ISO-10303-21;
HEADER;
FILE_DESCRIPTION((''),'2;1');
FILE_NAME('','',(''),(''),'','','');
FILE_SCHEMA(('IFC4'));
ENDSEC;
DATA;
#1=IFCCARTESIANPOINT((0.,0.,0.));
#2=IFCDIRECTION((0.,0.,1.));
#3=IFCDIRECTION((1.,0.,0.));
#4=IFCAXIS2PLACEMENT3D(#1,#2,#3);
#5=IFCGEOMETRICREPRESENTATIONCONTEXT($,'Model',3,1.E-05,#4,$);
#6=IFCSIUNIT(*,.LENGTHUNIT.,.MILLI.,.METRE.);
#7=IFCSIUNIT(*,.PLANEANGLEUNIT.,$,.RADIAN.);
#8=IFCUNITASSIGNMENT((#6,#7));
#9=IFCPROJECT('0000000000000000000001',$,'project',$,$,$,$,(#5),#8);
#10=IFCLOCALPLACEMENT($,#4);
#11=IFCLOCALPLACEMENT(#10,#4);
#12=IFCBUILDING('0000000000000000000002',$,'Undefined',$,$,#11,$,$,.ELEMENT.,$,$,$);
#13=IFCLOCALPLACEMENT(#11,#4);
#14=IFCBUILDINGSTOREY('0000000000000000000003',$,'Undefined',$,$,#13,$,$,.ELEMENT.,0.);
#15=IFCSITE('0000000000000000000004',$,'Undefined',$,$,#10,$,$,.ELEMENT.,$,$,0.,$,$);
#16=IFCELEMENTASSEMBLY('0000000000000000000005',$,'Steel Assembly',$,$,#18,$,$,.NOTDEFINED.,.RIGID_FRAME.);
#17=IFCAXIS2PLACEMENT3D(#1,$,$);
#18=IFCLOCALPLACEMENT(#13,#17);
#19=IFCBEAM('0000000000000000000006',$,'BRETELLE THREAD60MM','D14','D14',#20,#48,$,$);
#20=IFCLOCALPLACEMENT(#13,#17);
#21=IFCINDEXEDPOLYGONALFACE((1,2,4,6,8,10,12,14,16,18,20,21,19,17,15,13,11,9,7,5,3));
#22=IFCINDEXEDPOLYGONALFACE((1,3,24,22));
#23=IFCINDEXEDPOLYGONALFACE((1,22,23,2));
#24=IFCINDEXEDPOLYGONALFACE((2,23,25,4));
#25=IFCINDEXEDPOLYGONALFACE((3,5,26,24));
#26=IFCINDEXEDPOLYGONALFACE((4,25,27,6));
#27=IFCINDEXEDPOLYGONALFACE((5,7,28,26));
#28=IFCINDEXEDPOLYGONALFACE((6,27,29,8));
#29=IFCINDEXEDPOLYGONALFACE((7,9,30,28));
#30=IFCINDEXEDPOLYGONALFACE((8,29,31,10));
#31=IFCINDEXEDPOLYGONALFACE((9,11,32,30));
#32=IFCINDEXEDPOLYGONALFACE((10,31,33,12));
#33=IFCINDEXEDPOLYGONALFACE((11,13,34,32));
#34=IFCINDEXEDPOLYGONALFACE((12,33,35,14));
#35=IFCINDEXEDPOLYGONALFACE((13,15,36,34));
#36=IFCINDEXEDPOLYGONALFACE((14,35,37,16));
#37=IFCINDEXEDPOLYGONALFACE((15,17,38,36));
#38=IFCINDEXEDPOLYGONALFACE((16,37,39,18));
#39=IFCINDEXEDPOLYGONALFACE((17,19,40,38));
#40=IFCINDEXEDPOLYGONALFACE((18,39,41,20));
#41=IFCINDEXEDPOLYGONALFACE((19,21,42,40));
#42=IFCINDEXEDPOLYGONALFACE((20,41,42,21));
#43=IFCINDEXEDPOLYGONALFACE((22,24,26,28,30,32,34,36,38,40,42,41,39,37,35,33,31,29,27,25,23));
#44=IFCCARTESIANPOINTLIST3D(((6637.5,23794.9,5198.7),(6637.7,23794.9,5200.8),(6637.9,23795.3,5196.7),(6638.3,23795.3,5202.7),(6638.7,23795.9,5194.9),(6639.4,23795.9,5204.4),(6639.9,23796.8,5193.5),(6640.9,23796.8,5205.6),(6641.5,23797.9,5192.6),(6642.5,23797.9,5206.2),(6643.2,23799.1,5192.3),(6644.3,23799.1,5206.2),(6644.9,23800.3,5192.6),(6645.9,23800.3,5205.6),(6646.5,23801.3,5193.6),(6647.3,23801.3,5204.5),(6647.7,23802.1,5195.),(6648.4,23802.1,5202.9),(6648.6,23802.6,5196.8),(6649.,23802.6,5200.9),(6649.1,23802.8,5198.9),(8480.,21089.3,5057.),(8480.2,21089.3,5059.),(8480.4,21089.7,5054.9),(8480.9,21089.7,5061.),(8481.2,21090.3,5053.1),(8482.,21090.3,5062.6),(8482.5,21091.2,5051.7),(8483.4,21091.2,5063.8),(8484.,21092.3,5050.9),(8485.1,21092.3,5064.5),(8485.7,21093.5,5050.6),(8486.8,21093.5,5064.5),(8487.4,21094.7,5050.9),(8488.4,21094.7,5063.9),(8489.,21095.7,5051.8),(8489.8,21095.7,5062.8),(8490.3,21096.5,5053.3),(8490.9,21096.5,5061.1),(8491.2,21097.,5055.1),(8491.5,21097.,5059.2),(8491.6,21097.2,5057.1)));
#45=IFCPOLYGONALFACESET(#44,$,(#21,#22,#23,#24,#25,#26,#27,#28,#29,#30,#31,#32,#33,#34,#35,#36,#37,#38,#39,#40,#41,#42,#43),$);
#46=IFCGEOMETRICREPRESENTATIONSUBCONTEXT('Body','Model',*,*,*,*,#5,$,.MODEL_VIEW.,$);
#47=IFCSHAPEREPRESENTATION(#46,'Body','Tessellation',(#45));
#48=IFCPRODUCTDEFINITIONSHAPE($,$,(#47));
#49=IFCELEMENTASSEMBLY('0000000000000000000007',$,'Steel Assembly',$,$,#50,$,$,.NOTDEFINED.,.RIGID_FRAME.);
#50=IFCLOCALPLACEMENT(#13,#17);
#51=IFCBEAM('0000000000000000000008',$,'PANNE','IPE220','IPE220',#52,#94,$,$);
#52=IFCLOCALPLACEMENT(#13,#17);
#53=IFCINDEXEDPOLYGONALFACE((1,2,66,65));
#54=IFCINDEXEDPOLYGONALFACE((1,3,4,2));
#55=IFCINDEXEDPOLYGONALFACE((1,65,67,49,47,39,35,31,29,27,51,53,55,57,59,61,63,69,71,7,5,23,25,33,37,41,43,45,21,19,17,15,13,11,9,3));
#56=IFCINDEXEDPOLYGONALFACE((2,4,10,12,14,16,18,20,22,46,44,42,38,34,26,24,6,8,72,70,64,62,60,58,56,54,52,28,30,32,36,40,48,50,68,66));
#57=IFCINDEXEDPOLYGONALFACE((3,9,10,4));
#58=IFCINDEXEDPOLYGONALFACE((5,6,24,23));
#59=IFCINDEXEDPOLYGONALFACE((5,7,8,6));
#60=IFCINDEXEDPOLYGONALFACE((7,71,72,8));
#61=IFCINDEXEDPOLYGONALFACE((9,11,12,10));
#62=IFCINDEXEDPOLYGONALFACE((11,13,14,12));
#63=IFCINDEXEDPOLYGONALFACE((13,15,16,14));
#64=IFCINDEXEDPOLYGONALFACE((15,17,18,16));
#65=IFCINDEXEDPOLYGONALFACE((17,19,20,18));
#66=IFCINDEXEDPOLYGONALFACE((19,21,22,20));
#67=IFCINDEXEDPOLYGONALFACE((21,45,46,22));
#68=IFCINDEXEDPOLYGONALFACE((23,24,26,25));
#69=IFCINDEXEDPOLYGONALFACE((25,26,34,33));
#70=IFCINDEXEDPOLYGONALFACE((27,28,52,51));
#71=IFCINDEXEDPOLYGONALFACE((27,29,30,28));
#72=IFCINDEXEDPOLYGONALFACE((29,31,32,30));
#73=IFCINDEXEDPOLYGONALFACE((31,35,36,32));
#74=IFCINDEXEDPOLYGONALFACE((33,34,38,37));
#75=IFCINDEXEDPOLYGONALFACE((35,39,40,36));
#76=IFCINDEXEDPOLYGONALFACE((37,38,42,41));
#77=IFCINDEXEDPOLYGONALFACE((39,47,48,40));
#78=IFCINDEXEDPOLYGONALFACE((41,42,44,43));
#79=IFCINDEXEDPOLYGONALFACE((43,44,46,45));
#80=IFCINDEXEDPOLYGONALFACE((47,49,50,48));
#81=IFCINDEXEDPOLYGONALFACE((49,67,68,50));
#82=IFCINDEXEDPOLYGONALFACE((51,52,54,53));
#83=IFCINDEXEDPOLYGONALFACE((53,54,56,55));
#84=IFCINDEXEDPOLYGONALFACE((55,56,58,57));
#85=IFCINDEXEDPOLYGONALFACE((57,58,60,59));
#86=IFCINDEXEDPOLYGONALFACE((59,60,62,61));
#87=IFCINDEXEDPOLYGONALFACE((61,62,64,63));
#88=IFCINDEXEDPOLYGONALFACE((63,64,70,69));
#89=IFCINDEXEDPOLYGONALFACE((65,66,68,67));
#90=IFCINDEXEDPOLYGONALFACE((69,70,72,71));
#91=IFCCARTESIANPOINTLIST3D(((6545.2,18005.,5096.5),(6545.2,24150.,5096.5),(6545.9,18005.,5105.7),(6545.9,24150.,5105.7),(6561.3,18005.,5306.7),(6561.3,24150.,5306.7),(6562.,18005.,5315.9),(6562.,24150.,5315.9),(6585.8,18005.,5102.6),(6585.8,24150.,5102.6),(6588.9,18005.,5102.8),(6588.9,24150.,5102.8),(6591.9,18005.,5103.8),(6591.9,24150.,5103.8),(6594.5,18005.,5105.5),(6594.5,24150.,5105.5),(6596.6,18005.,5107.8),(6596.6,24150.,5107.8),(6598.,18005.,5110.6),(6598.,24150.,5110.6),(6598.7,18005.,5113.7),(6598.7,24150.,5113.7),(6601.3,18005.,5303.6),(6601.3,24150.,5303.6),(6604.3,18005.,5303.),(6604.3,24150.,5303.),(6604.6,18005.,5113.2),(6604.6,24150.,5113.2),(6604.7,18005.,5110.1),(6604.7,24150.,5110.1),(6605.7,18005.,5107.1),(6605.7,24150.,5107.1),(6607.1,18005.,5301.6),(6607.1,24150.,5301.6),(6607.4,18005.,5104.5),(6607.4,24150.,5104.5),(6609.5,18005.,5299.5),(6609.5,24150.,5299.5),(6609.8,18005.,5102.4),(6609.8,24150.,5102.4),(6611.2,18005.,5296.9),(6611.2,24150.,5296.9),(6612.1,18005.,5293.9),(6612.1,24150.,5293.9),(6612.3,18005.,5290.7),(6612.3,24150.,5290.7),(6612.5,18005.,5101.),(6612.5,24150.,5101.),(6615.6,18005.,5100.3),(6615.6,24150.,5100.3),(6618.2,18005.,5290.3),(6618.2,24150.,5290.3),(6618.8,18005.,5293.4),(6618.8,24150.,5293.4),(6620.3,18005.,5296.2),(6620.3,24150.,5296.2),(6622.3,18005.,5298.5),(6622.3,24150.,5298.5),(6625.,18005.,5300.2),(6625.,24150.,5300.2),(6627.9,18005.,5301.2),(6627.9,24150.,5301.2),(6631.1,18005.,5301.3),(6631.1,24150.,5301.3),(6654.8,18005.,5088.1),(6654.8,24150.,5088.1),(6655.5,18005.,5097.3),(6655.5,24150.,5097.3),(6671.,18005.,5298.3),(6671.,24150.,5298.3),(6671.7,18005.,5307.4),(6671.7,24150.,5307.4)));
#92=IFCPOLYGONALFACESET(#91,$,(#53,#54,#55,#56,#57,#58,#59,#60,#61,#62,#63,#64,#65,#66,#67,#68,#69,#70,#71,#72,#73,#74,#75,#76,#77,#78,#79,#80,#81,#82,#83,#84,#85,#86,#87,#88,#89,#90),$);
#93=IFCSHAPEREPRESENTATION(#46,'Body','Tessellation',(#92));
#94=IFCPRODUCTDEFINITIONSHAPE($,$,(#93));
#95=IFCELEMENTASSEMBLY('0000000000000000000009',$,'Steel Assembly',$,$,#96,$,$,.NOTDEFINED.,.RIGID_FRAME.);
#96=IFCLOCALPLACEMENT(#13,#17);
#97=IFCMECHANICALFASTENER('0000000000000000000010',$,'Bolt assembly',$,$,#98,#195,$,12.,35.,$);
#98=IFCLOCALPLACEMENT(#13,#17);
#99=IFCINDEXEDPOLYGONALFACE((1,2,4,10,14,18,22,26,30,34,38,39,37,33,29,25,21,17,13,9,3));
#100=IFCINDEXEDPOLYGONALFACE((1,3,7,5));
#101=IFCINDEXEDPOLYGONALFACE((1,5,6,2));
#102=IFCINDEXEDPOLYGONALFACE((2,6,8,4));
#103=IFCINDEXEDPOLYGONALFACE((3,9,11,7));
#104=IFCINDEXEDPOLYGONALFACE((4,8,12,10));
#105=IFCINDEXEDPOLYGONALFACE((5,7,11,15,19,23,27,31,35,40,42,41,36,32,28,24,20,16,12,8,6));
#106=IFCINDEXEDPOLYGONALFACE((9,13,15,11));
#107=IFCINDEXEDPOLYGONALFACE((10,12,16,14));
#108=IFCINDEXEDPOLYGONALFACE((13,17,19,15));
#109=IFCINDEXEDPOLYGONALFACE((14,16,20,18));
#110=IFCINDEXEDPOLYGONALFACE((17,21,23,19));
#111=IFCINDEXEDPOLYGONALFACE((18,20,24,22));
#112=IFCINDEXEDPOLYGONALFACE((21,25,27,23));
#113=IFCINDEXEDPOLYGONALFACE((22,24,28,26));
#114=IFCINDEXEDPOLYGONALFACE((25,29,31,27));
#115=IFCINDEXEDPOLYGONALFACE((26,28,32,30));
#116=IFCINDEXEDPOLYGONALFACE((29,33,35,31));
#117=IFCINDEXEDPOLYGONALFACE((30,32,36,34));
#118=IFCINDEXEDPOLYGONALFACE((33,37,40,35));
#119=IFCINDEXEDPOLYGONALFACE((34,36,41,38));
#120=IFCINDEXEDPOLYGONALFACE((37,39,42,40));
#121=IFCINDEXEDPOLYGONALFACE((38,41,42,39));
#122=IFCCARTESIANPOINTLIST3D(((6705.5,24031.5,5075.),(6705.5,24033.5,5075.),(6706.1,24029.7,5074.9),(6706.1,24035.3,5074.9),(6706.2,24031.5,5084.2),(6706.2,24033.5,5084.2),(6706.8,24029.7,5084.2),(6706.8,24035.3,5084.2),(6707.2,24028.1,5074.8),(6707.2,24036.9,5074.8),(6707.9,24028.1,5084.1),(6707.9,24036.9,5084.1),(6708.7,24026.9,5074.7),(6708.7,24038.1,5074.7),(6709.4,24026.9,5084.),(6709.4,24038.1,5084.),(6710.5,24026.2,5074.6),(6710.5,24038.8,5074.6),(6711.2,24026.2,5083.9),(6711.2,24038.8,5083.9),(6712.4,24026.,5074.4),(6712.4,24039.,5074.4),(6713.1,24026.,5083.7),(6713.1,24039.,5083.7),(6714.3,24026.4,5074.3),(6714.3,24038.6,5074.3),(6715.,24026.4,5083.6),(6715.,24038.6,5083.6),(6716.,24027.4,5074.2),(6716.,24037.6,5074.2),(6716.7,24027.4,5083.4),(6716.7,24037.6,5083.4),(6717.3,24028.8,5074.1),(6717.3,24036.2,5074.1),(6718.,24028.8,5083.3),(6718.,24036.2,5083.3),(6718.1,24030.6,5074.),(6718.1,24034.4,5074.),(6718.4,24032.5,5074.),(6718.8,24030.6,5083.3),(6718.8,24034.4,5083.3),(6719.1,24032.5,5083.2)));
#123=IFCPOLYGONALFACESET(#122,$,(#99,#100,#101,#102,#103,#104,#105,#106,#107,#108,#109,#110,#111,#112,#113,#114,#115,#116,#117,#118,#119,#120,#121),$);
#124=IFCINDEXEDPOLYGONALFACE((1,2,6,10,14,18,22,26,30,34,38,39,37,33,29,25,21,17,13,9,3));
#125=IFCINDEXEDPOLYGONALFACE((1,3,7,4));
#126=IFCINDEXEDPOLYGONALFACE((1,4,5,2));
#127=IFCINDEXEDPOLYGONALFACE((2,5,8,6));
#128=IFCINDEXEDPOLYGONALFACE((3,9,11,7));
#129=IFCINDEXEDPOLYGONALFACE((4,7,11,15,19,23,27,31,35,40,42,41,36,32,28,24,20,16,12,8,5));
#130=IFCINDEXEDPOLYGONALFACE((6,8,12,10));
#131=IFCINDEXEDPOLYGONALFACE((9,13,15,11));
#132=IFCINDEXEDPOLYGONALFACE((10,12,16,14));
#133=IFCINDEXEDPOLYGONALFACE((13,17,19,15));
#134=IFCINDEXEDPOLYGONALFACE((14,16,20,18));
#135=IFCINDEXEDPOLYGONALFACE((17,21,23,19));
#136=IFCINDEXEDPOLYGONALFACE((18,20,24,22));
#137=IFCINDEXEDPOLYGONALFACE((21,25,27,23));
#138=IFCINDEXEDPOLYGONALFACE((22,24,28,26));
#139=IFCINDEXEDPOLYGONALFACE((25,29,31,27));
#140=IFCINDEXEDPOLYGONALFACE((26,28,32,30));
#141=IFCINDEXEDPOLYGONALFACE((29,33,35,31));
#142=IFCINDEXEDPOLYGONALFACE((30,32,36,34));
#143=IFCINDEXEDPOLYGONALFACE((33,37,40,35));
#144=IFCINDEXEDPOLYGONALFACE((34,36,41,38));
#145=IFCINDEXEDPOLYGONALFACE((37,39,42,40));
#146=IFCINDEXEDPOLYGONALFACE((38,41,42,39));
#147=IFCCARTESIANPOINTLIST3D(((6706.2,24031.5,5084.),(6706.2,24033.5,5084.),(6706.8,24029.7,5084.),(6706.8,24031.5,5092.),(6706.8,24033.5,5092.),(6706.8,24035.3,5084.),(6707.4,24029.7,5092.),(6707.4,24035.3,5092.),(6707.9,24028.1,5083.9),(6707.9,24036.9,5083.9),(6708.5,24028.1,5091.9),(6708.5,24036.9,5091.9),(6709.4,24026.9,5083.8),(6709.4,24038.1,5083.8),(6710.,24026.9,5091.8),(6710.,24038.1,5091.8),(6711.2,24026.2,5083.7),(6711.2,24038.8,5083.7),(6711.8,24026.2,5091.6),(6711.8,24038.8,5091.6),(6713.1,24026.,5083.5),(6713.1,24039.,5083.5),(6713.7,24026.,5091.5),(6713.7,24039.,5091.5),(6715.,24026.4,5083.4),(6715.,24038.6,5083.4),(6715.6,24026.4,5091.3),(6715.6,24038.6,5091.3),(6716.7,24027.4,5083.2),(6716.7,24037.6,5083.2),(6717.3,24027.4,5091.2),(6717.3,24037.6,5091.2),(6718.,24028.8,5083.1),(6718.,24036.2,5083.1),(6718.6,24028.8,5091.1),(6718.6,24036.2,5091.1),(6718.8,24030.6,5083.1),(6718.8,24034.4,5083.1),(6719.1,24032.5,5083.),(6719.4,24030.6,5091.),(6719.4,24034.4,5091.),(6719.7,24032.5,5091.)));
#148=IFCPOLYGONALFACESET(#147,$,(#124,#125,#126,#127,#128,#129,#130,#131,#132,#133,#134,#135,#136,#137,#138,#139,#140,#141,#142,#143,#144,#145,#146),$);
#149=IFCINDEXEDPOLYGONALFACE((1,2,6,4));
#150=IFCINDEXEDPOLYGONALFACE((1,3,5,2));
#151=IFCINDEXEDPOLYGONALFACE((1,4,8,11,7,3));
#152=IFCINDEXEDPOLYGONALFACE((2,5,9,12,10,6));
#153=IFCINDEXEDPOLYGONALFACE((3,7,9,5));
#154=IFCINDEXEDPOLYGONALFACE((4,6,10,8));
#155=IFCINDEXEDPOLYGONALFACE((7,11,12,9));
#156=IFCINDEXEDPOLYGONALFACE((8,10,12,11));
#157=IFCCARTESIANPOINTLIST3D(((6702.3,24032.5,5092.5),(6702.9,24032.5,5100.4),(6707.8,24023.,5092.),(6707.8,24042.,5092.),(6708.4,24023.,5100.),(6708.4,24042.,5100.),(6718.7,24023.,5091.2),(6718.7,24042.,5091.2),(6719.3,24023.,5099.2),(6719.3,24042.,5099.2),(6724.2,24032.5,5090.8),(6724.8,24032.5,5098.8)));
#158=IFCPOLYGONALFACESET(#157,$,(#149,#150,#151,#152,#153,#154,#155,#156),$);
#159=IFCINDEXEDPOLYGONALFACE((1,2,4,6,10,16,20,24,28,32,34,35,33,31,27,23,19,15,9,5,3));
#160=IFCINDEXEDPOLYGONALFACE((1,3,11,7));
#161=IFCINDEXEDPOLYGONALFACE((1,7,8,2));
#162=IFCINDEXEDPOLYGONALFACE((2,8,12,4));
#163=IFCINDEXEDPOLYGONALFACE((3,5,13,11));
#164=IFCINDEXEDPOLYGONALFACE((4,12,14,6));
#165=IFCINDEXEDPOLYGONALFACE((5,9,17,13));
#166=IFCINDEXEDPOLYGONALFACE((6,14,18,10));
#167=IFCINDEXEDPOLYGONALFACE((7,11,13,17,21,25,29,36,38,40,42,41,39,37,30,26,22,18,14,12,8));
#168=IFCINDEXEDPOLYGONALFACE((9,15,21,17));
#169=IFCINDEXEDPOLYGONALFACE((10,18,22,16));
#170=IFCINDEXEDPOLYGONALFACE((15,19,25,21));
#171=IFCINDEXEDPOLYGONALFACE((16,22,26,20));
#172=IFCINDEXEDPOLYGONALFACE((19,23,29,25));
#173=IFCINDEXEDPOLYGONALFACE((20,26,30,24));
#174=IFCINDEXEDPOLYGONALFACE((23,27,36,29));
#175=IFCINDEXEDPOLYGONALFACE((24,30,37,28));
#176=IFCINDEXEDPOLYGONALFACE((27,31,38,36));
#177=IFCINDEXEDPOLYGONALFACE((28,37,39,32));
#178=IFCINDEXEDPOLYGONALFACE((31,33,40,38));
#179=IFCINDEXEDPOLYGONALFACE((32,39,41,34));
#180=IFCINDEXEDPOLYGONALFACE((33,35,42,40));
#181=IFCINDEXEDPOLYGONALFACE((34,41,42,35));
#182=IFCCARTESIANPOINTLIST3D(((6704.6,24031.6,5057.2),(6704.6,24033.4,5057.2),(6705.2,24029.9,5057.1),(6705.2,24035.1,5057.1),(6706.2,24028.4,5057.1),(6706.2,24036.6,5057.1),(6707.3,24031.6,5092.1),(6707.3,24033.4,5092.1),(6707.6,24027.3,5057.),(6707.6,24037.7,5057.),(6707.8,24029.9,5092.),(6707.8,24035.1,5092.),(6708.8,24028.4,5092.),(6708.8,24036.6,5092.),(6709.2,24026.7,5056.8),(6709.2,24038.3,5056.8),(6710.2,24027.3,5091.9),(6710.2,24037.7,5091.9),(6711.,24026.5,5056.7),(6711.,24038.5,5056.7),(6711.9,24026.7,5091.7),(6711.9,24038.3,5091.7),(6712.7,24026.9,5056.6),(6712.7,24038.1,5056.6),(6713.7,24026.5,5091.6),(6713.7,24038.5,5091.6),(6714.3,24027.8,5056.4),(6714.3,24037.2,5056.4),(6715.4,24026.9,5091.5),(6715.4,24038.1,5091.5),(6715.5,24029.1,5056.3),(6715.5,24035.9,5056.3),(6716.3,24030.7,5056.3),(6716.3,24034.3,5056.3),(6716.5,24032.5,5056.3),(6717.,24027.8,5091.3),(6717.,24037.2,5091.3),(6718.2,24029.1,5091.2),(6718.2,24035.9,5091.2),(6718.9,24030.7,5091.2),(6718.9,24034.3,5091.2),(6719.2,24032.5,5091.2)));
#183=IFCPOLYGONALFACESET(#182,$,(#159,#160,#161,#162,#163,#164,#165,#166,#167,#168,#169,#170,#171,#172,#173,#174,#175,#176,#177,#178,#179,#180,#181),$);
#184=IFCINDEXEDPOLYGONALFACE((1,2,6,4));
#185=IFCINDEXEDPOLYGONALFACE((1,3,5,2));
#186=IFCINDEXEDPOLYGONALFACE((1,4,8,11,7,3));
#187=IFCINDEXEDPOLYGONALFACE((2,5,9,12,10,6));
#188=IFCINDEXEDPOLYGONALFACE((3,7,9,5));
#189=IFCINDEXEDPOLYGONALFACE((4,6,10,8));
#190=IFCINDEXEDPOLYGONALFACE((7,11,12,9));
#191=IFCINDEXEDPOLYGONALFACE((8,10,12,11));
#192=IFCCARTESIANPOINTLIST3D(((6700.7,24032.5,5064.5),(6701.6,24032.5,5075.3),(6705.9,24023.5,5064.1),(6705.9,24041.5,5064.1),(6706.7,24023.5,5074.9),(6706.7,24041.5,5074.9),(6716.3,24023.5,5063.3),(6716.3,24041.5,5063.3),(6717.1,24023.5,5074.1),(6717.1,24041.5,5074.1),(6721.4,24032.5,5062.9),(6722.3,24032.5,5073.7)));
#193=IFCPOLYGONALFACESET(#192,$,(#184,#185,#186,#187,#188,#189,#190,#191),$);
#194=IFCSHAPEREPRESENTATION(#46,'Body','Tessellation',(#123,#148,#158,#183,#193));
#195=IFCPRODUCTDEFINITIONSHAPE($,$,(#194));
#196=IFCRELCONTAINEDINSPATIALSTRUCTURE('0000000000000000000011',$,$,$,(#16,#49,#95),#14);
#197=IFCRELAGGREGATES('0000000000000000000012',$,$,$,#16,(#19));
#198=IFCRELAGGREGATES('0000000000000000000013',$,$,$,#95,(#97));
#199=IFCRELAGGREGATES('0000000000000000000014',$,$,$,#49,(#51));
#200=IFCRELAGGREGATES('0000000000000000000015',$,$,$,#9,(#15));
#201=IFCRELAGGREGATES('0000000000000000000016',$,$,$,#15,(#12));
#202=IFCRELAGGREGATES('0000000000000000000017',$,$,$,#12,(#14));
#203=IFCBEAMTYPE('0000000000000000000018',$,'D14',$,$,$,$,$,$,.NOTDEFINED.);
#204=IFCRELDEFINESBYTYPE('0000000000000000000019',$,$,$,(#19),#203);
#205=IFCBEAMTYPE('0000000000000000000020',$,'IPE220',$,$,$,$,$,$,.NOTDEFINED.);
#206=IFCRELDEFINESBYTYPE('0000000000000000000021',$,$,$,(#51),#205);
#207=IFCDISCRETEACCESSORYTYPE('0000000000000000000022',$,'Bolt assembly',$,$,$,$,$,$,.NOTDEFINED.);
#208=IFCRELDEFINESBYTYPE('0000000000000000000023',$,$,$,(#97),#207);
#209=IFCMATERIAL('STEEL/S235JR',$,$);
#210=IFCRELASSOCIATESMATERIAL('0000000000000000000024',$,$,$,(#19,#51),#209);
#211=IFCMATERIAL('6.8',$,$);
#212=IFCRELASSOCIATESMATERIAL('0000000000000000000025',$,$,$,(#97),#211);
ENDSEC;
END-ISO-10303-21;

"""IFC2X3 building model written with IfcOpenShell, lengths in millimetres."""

from ifc_helpers import new_model, si_unit, frame, origin_with_axes, origin_2d_with_axis, place, context, subcontext, project, spatial, polyline, circle, i_section, outline, extrude, clip, halfspace, source, transform, mapped, material, type_object, element, aggregate, save


model = new_model("IFC2X3")

# Units and contexts
model_context = context("Model", 3, precision=1e-05, world=origin_with_axes())
body_context = subcontext(model_context, "Body", "Model", "MODEL_VIEW")
ifc_project = project(units=[si_unit("LENGTHUNIT", "METRE", prefix="MILLI"), si_unit("PLANEANGLEUNIT", "RADIAN")], contexts=[model_context])

# Site, building, storey
site_placement = place(None, origin_with_axes())
site = spatial("IfcSite", under=ifc_project, at=site_placement, Name="Undefined", CompositionType="ELEMENT", RefElevation=0.0)
building_placement = place(site_placement, origin_with_axes())
building = spatial("IfcBuilding", under=site, at=building_placement, Name="Undefined", CompositionType="ELEMENT")
storey_placement = place(building_placement, origin_with_axes())
storey = spatial("IfcBuildingStorey", under=building, at=storey_placement, Name="Undefined", CompositionType="ELEMENT", Elevation=0.0)

# Element assemblies, beams
assembly_1_placement = place(storey_placement, origin_with_axes())
assembly_1 = element("IfcElementAssembly", 1, at=assembly_1_placement, inside=storey, Name="Steel Assembly", AssemblyPlace="NOTDEFINED", PredefinedType="RIGID_FRAME")
ifc_material_1 = material(Name="STEEL/S235JR")
beam_type_1 = type_object("IfcBeamType", Name="D14", PredefinedType="NOTDEFINED")
beam_1_placement = place(assembly_1_placement, frame((6643.3, 23798.8, 5199.3), z_axis=(-0.076696, 0.0, -0.997054), x_axis=(0.56235, -0.825767, -0.043258)))
beam_1 = element("IfcBeam", 2, at=beam_1_placement, type_object=beam_type_1, material=ifc_material_1, Name="BRETELLE THREAD60MM", Description="D14", ObjectType="D14", context=body_context, shape_type="SweptSolid", body=[
    extrude(circle(Radius=7.0, at=origin_2d_with_axis()), frame((3276.5, 0.0, 0.0), z_axis=(-1.0, 0.0, 0.0), x_axis=(0.0, -1.0, 0.0)), (0.0, 0.0, 1.0), 3276.5),
])
aggregate(assembly_1, [beam_1])
assembly_2_placement = place(storey_placement, origin_with_axes())
assembly_2 = element("IfcElementAssembly", 3, at=assembly_2_placement, inside=storey, Name="Steel Assembly", AssemblyPlace="NOTDEFINED", PredefinedType="RIGID_FRAME")
beam_type_2 = type_object("IfcBeamType", Name="IPE220", PredefinedType="NOTDEFINED")
beam_2_placement = place(assembly_2_placement, frame((6608.4, 18000.0, 5202.0), z_axis=(0.076696, 0.0, 0.997054), x_axis=(0.0, 1.0, 0.0)))
beam_2 = element("IfcBeam", 4, at=beam_2_placement, type_object=beam_type_2, material=ifc_material_1, Name="PANNE", Description="IPE220", ObjectType="IPE220", context=body_context, shape_type="Clipping", body=[
    clip(extrude(i_section(OverallWidth=110.0, OverallDepth=220.0, WebThickness=5.9, FlangeThickness=9.2, FilletRadius=12.0, at=origin_2d_with_axis()), frame((6150.0, 0.0, 0.0), z_axis=(-1.0, 0.0, 0.0), x_axis=(0.0, -1.0, 0.0)), (0.0, 0.0, 1.0), 6145.0), halfspace(frame((5.0, 0.0, 0.0), z_axis=(1.0, 0.0, 0.0), x_axis=(0.0, -1.0, 0.0)), True)),
])

# Element assembly, mechanical fastener
assembly_3_placement = place(storey_placement, origin_with_axes())
assembly_3 = element("IfcElementAssembly", 5, at=assembly_3_placement, inside=storey, Name="Steel Assembly", AssemblyPlace="NOTDEFINED", PredefinedType="RIGID_FRAME")
ifc_material_2 = material(Name="6.8")
discrete_accessory_type_1 = type_object("IfcDiscreteAccessoryType", Name="Bolt assembly")
shared_shape_1 = source(origin_with_axes(), body_context, "Body", "SweptSolid", [
    extrude(circle(Radius=6.5, at=origin_2d_with_axis()), frame((0.0, -0.1, 0.0), z_axis=(0.0, 1.0, 0.0), x_axis=(1.0, 0.0, 0.0)), (0.0, 0.0, 1.0), 9.3),
    extrude(circle(Radius=6.5, at=origin_2d_with_axis()), frame((0.0, -7.9, 0.0), z_axis=(0.0, 1.0, 0.0), x_axis=(1.0, 0.0, 0.0)), (0.0, 0.0, 1.0), 8.0),
    extrude(outline(polyline([(11.0, 0.0), (5.5, 9.5), (-5.5, 9.5), (-11.0, 0.0), (-5.5, -9.5), (5.5, -9.5), (11.0, 0.0)])), frame((0.0, -16.0, 0.0), z_axis=(0.0, 1.0, 0.0), x_axis=(1.0, 0.0, 0.0)), (0.0, 0.0, 1.0), 8.0),
    extrude(circle(Radius=6.0, at=origin_2d_with_axis()), frame((0.0, -8.0, 0.0), z_axis=(0.0, 1.0, 0.0), x_axis=(1.0, 0.0, 0.0)), (0.0, 0.0, 1.0), 35.0),
    extrude(outline(polyline([(10.4, 0.0), (5.2, 9.0), (-5.2, 9.0), (-10.4, 0.0), (-5.2, -9.0), (5.2, -9.0), (10.4, 0.0)])), frame((0.0, 9.2, 0.0), z_axis=(0.0, 1.0, 0.0), x_axis=(1.0, 0.0, 0.0)), (0.0, 0.0, 1.0), 10.8),
])
mechanical_fastener_1_placement = place(assembly_3_placement, frame((6712.6, 24032.5, 5083.6), z_axis=(0.0, 1.0, 0.0), x_axis=(0.997054, 0.0, -0.076696)))
mechanical_fastener_1 = element("IfcMechanicalFastener", 6, at=mechanical_fastener_1_placement, type_object=discrete_accessory_type_1, material=ifc_material_2, Name="Bolt assembly", NominalDiameter=12.0, NominalLength=35.0, context=body_context, shape_type="MappedRepresentation", body=[
    mapped(shared_shape_1, transform((0.0, 0.0, 0.0))),
])
aggregate(assembly_3, [mechanical_fastener_1])

aggregate(assembly_2, [beam_2])

save(model, "model.ifc")
